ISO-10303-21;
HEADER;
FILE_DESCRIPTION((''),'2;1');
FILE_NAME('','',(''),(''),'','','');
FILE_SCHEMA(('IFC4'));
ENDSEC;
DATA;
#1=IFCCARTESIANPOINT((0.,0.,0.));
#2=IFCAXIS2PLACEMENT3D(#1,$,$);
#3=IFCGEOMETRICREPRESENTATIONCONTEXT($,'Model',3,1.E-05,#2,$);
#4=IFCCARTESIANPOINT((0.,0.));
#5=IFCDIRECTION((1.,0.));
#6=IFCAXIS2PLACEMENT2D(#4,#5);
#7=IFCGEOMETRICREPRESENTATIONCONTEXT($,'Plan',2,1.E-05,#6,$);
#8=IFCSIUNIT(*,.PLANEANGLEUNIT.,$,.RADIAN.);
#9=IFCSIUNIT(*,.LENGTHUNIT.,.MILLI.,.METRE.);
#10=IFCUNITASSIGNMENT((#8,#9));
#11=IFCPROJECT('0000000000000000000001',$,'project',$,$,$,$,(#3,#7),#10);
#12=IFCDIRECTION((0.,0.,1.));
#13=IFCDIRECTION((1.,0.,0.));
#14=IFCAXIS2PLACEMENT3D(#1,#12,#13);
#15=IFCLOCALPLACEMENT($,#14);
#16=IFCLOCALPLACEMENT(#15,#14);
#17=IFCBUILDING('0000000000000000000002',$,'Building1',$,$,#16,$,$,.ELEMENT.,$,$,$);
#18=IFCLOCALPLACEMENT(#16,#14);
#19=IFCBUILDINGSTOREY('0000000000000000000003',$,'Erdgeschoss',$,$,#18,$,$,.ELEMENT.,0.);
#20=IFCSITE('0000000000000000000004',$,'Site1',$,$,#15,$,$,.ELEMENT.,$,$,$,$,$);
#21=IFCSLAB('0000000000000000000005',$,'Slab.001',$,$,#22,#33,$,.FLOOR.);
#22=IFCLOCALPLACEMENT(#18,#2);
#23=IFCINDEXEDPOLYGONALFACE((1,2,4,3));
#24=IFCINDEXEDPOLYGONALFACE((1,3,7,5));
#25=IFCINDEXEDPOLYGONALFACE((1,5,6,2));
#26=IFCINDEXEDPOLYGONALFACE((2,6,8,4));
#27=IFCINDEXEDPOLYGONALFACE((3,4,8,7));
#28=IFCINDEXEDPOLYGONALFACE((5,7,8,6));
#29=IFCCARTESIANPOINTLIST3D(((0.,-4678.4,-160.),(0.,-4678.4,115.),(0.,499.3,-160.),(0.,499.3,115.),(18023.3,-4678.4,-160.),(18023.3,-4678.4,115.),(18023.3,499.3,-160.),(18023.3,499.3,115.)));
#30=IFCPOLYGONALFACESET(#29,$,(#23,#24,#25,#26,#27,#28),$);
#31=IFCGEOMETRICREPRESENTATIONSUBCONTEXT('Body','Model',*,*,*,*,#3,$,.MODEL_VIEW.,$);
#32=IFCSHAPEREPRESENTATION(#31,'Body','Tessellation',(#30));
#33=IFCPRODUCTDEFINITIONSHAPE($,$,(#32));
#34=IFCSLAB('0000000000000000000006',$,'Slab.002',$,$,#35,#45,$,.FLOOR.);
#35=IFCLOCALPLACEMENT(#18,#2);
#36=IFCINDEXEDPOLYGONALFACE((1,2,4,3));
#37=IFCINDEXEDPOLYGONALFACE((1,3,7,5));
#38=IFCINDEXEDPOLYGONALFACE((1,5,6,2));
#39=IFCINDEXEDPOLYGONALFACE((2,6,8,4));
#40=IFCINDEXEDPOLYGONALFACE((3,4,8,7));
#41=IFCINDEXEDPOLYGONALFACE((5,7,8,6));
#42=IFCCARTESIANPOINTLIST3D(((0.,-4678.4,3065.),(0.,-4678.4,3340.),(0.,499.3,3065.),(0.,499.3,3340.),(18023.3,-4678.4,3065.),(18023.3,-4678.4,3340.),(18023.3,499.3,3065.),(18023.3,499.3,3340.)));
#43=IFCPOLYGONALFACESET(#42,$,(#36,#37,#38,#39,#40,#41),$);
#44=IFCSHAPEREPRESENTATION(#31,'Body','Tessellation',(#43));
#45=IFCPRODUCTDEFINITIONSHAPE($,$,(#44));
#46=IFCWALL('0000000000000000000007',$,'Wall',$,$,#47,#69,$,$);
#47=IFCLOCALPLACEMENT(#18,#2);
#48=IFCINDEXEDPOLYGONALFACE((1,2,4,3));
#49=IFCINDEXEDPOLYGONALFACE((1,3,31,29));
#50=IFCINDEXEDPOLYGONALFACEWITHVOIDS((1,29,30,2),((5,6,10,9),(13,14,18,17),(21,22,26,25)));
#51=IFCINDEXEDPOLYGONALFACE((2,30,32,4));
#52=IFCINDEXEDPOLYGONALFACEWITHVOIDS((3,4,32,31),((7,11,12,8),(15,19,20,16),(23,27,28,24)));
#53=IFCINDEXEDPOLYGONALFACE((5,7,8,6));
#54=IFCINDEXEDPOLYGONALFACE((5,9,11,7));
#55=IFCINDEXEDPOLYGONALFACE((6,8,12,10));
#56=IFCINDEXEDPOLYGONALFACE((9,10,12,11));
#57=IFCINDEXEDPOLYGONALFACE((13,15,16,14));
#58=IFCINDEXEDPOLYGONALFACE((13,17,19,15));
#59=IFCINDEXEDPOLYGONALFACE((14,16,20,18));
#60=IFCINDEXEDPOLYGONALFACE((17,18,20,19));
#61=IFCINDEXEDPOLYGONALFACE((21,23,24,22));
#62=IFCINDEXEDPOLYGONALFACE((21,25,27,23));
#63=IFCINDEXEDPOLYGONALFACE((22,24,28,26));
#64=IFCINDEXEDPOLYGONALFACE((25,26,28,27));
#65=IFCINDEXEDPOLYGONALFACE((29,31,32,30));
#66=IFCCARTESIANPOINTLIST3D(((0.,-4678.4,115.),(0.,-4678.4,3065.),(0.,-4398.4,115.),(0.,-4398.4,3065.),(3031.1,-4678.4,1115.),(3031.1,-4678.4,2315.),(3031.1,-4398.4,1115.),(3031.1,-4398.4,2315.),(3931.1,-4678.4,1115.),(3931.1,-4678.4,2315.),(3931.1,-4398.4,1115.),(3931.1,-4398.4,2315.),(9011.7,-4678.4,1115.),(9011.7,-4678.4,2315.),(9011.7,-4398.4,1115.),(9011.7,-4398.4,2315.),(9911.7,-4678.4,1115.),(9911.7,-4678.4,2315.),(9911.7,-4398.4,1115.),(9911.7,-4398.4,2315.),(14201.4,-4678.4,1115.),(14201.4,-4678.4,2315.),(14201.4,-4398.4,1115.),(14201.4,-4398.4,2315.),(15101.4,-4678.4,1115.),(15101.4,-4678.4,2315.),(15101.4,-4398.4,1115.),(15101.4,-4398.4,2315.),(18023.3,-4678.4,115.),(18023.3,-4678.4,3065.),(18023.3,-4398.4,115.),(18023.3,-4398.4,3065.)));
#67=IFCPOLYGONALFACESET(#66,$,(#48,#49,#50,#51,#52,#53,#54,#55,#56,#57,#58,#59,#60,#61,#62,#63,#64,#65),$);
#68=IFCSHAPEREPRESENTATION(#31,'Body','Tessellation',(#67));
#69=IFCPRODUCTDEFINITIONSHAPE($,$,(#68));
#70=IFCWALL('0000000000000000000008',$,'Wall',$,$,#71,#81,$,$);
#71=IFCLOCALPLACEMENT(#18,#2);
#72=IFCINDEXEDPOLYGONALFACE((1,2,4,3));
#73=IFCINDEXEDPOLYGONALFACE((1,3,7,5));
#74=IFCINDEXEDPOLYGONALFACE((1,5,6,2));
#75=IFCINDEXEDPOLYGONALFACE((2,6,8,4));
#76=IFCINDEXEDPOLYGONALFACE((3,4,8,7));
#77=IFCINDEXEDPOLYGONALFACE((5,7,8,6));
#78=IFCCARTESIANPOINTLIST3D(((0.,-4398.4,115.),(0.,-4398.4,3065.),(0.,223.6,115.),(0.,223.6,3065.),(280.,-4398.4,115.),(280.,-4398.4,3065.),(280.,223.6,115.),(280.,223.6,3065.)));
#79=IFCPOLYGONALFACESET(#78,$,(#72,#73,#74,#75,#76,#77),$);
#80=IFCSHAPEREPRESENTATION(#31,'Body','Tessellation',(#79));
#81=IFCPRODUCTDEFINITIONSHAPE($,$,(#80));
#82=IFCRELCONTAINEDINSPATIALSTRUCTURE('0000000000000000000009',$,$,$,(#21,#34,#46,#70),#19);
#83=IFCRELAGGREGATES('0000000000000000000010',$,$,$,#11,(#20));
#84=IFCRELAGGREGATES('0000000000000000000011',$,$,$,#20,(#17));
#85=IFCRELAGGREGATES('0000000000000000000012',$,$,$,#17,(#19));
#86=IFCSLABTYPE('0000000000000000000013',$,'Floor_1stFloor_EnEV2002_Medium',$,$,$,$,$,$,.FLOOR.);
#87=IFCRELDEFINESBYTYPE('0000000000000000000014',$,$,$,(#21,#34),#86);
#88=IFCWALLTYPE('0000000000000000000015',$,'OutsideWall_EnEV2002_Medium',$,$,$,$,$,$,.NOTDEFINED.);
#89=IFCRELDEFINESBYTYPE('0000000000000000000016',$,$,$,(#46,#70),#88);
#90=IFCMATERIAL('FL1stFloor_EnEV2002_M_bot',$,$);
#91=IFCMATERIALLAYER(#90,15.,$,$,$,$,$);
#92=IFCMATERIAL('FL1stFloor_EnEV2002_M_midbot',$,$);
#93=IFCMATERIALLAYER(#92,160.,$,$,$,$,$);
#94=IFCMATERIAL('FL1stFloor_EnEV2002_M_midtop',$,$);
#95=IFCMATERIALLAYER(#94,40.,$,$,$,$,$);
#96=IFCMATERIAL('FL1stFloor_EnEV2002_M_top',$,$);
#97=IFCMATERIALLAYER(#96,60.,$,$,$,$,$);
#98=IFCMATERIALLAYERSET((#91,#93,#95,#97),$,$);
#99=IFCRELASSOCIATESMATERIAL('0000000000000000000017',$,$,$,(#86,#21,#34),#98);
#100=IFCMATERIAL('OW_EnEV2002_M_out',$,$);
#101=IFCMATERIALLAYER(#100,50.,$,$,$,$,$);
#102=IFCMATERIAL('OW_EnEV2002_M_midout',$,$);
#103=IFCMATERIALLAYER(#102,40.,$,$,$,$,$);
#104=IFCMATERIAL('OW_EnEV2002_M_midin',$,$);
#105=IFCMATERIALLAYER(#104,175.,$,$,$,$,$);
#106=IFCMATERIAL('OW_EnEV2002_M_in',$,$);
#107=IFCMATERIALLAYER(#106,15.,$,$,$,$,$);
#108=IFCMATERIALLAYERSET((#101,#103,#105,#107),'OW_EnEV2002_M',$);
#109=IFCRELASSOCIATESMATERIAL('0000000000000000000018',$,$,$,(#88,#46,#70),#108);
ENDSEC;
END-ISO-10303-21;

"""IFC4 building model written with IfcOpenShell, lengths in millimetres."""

from ifc_helpers import new_model, si_unit, frame, origin, origin_with_axes, origin_2d_with_axis, place, context, subcontext, project, spatial, line, indexed_curve, outline, extrude, source, transform, mapped, material, layer, layer_set, layer_usage, type_object, element, save


model = new_model("IFC4")

# Units and contexts
model_context = context("Model", 3, precision=1e-05, world=origin())
plan_context = context("Plan", 2, precision=1e-05, world=origin_2d_with_axis())
body_context = subcontext(model_context, "Body", "Model", "MODEL_VIEW")
ifc_project = project(units=[si_unit("PLANEANGLEUNIT", "RADIAN"), si_unit("LENGTHUNIT", "METRE", prefix="MILLI")], contexts=[model_context, plan_context])

# Site, building, storey
site_placement = place(None, origin_with_axes())
site = spatial("IfcSite", under=ifc_project, at=site_placement, Name="Site1", CompositionType="ELEMENT")
building_placement = place(site_placement, origin_with_axes())
building = spatial("IfcBuilding", under=site, at=building_placement, Name="Building1", CompositionType="ELEMENT")
storey_placement = place(building_placement, origin_with_axes())
storey = spatial("IfcBuildingStorey", under=building, at=storey_placement, Name="Erdgeschoss", CompositionType="ELEMENT", Elevation=0.0)

# Slabs
ifc_material_1 = material(Name="FL1stFloor_EnEV2002_M_bot")
ifc_layer_1 = layer(ifc_material_1, 15.0)
ifc_material_2 = material(Name="FL1stFloor_EnEV2002_M_midbot")
ifc_layer_2 = layer(ifc_material_2, 160.0)
ifc_material_3 = material(Name="FL1stFloor_EnEV2002_M_midtop")
ifc_layer_3 = layer(ifc_material_3, 40.0)
ifc_material_4 = material(Name="FL1stFloor_EnEV2002_M_top")
ifc_layer_4 = layer(ifc_material_4, 60.0)
ifc_layer_set_1 = layer_set([ifc_layer_1, ifc_layer_2, ifc_layer_3, ifc_layer_4])
ifc_layer_usage_1 = layer_usage(ifc_layer_set_1, "AXIS3", "POSITIVE", 0.0)
slab_type = type_object("IfcSlabType", Name="Floor_1stFloor_EnEV2002_Medium", PredefinedType="FLOOR", material=ifc_layer_set_1)
slab_1_placement = place(storey_placement, frame((0.0, -4678.4, -160.0), z_axis=(0.0, 0.0, 1.0), x_axis=(1.0, 0.0, 0.0)))
element("IfcSlab", 1, at=slab_1_placement, inside=storey, type_object=slab_type, material=ifc_layer_usage_1, Name="Slab.001", PredefinedType="FLOOR", context=body_context, shape_type="SweptSolid", body=[
    extrude(outline(indexed_curve([(0.0, 0.0), (18023.3, 0.0), (18023.3, 5177.6), (0.0, 5177.6)], segments=[line(3, 2), line(2, 1), line(1, 4), line(4, 3)], self_intersect=False)), None, (0.0, 0.0, 1.0), 275.0),
])
ifc_layer_usage_2 = layer_usage(ifc_layer_set_1, "AXIS3", "POSITIVE", 0.0)
slab_2_placement = place(storey_placement, frame((0.0, -4678.4, 3065.0), z_axis=(0.0, 0.0, 1.0), x_axis=(1.0, 0.0, 0.0)))
element("IfcSlab", 2, at=slab_2_placement, inside=storey, type_object=slab_type, material=ifc_layer_usage_2, Name="Slab.002", PredefinedType="FLOOR", context=body_context, shape_type="SweptSolid", body=[
    extrude(outline(indexed_curve([(0.0, 0.0), (18023.3, 0.0), (18023.3, 5177.6), (0.0, 5177.6)], segments=[line(3, 2), line(2, 1), line(1, 4), line(4, 3)], self_intersect=False)), None, (0.0, 0.0, 1.0), 275.0),
])

# Wall, openings
ifc_material_5 = material(Name="OW_EnEV2002_M_out")
ifc_layer_5 = layer(ifc_material_5, 50.0)
ifc_material_6 = material(Name="OW_EnEV2002_M_midout")
ifc_layer_6 = layer(ifc_material_6, 40.0)
ifc_material_7 = material(Name="OW_EnEV2002_M_midin")
ifc_layer_7 = layer(ifc_material_7, 175.0)
ifc_material_8 = material(Name="OW_EnEV2002_M_in")
ifc_layer_8 = layer(ifc_material_8, 15.0)
ifc_layer_set_2 = layer_set([ifc_layer_5, ifc_layer_6, ifc_layer_7, ifc_layer_8], Name="OW_EnEV2002_M")
ifc_layer_usage_3 = layer_usage(ifc_layer_set_2, "AXIS2", "POSITIVE", 0.0)
wall_type = type_object("IfcWallType", Name="OutsideWall_EnEV2002_Medium", PredefinedType="NOTDEFINED", material=ifc_layer_set_2)
wall_1_placement = place(storey_placement, frame((0.0, -4678.4, 115.0), z_axis=(0.0, 0.0, 1.0), x_axis=(1.0, 0.0, 0.0)))
wall_1 = element("IfcWall", 3, at=wall_1_placement, inside=storey, type_object=wall_type, material=ifc_layer_usage_3, Name="Wall", context=body_context, shape_type="SweptSolid", body=[
    extrude(outline(indexed_curve([(0.0, 0.0), (0.0, 280.0), (18023.3, 280.0), (18023.3, 0.0), (0.0, 0.0)], self_intersect=False)), origin_with_axes(), (0.0, 0.0, 1.0), 2950.0),
])
shared_shape_1 = source(origin_with_axes(), body_context, "Body", "SweptSolid", [
    extrude(outline(indexed_curve([(0.0, 0.0), (900.0, 0.0), (900.0, 1200.0), (0.0, 1200.0)], segments=[line(1, 2, 3, 4, 1)])), frame((0.0, -600.0, 0.0), z_axis=(0.0, -1.0, 0.0), x_axis=(1.0, 0.0, 0.0)), (0.0, 0.0, -1.0), 1200.0),
])
opening_1_placement = place(wall_1_placement, frame((9011.7, 0.0, 1000.0), z_axis=(0.0, 0.0, 1.0), x_axis=(1.0, 0.0, 0.0)))
element("IfcOpeningElement", 4, at=opening_1_placement, cuts=wall_1, PredefinedType="OPENING", context=body_context, shape_type="MappedRepresentation", body=[
    mapped(shared_shape_1, transform((0.0, 0.0, 0.0), x_axis=(1.0, 0.0, 0.0), y_axis=(0.0, 1.0, 0.0), z_axis=(0.0, 0.0, 1.0), scale=1.0)),
])
opening_2_placement = place(wall_1_placement, frame((3031.1, 0.0, 1000.0), z_axis=(0.0, 0.0, 1.0), x_axis=(1.0, 0.0, 0.0)))
element("IfcOpeningElement", 5, at=opening_2_placement, cuts=wall_1, PredefinedType="OPENING", context=body_context, shape_type="MappedRepresentation", body=[
    mapped(shared_shape_1, transform((0.0, 0.0, 0.0), x_axis=(1.0, 0.0, 0.0), y_axis=(0.0, 1.0, 0.0), z_axis=(0.0, 0.0, 1.0), scale=1.0)),
])
opening_3_placement = place(wall_1_placement, frame((14201.4, 0.0, 1000.0), z_axis=(0.0, 0.0, 1.0), x_axis=(1.0, 0.0, 0.0)))
element("IfcOpeningElement", 6, at=opening_3_placement, cuts=wall_1, PredefinedType="OPENING", context=body_context, shape_type="MappedRepresentation", body=[
    mapped(shared_shape_1, transform((0.0, 0.0, 0.0), x_axis=(1.0, 0.0, 0.0), y_axis=(0.0, 1.0, 0.0), z_axis=(0.0, 0.0, 1.0), scale=1.0)),
])

# Wall
ifc_layer_usage_4 = layer_usage(ifc_layer_set_2, "AXIS2", "POSITIVE", 0.0)
wall_2_placement = place(storey_placement, frame((280.0, -4398.4, 115.0), z_axis=(0.0, 0.0, 1.0), x_axis=(0.0, 1.0, 0.0)))
element("IfcWall", 7, at=wall_2_placement, inside=storey, type_object=wall_type, material=ifc_layer_usage_4, Name="Wall", context=body_context, shape_type="SweptSolid", body=[
    extrude(outline(indexed_curve([(0.0, 0.0), (0.0, 280.0), (4622.0, 280.0), (4622.0, 0.0), (0.0, 0.0)], self_intersect=False)), origin_with_axes(), (0.0, 0.0, 1.0), 2950.0),
])

save(model, "model.ifc")
